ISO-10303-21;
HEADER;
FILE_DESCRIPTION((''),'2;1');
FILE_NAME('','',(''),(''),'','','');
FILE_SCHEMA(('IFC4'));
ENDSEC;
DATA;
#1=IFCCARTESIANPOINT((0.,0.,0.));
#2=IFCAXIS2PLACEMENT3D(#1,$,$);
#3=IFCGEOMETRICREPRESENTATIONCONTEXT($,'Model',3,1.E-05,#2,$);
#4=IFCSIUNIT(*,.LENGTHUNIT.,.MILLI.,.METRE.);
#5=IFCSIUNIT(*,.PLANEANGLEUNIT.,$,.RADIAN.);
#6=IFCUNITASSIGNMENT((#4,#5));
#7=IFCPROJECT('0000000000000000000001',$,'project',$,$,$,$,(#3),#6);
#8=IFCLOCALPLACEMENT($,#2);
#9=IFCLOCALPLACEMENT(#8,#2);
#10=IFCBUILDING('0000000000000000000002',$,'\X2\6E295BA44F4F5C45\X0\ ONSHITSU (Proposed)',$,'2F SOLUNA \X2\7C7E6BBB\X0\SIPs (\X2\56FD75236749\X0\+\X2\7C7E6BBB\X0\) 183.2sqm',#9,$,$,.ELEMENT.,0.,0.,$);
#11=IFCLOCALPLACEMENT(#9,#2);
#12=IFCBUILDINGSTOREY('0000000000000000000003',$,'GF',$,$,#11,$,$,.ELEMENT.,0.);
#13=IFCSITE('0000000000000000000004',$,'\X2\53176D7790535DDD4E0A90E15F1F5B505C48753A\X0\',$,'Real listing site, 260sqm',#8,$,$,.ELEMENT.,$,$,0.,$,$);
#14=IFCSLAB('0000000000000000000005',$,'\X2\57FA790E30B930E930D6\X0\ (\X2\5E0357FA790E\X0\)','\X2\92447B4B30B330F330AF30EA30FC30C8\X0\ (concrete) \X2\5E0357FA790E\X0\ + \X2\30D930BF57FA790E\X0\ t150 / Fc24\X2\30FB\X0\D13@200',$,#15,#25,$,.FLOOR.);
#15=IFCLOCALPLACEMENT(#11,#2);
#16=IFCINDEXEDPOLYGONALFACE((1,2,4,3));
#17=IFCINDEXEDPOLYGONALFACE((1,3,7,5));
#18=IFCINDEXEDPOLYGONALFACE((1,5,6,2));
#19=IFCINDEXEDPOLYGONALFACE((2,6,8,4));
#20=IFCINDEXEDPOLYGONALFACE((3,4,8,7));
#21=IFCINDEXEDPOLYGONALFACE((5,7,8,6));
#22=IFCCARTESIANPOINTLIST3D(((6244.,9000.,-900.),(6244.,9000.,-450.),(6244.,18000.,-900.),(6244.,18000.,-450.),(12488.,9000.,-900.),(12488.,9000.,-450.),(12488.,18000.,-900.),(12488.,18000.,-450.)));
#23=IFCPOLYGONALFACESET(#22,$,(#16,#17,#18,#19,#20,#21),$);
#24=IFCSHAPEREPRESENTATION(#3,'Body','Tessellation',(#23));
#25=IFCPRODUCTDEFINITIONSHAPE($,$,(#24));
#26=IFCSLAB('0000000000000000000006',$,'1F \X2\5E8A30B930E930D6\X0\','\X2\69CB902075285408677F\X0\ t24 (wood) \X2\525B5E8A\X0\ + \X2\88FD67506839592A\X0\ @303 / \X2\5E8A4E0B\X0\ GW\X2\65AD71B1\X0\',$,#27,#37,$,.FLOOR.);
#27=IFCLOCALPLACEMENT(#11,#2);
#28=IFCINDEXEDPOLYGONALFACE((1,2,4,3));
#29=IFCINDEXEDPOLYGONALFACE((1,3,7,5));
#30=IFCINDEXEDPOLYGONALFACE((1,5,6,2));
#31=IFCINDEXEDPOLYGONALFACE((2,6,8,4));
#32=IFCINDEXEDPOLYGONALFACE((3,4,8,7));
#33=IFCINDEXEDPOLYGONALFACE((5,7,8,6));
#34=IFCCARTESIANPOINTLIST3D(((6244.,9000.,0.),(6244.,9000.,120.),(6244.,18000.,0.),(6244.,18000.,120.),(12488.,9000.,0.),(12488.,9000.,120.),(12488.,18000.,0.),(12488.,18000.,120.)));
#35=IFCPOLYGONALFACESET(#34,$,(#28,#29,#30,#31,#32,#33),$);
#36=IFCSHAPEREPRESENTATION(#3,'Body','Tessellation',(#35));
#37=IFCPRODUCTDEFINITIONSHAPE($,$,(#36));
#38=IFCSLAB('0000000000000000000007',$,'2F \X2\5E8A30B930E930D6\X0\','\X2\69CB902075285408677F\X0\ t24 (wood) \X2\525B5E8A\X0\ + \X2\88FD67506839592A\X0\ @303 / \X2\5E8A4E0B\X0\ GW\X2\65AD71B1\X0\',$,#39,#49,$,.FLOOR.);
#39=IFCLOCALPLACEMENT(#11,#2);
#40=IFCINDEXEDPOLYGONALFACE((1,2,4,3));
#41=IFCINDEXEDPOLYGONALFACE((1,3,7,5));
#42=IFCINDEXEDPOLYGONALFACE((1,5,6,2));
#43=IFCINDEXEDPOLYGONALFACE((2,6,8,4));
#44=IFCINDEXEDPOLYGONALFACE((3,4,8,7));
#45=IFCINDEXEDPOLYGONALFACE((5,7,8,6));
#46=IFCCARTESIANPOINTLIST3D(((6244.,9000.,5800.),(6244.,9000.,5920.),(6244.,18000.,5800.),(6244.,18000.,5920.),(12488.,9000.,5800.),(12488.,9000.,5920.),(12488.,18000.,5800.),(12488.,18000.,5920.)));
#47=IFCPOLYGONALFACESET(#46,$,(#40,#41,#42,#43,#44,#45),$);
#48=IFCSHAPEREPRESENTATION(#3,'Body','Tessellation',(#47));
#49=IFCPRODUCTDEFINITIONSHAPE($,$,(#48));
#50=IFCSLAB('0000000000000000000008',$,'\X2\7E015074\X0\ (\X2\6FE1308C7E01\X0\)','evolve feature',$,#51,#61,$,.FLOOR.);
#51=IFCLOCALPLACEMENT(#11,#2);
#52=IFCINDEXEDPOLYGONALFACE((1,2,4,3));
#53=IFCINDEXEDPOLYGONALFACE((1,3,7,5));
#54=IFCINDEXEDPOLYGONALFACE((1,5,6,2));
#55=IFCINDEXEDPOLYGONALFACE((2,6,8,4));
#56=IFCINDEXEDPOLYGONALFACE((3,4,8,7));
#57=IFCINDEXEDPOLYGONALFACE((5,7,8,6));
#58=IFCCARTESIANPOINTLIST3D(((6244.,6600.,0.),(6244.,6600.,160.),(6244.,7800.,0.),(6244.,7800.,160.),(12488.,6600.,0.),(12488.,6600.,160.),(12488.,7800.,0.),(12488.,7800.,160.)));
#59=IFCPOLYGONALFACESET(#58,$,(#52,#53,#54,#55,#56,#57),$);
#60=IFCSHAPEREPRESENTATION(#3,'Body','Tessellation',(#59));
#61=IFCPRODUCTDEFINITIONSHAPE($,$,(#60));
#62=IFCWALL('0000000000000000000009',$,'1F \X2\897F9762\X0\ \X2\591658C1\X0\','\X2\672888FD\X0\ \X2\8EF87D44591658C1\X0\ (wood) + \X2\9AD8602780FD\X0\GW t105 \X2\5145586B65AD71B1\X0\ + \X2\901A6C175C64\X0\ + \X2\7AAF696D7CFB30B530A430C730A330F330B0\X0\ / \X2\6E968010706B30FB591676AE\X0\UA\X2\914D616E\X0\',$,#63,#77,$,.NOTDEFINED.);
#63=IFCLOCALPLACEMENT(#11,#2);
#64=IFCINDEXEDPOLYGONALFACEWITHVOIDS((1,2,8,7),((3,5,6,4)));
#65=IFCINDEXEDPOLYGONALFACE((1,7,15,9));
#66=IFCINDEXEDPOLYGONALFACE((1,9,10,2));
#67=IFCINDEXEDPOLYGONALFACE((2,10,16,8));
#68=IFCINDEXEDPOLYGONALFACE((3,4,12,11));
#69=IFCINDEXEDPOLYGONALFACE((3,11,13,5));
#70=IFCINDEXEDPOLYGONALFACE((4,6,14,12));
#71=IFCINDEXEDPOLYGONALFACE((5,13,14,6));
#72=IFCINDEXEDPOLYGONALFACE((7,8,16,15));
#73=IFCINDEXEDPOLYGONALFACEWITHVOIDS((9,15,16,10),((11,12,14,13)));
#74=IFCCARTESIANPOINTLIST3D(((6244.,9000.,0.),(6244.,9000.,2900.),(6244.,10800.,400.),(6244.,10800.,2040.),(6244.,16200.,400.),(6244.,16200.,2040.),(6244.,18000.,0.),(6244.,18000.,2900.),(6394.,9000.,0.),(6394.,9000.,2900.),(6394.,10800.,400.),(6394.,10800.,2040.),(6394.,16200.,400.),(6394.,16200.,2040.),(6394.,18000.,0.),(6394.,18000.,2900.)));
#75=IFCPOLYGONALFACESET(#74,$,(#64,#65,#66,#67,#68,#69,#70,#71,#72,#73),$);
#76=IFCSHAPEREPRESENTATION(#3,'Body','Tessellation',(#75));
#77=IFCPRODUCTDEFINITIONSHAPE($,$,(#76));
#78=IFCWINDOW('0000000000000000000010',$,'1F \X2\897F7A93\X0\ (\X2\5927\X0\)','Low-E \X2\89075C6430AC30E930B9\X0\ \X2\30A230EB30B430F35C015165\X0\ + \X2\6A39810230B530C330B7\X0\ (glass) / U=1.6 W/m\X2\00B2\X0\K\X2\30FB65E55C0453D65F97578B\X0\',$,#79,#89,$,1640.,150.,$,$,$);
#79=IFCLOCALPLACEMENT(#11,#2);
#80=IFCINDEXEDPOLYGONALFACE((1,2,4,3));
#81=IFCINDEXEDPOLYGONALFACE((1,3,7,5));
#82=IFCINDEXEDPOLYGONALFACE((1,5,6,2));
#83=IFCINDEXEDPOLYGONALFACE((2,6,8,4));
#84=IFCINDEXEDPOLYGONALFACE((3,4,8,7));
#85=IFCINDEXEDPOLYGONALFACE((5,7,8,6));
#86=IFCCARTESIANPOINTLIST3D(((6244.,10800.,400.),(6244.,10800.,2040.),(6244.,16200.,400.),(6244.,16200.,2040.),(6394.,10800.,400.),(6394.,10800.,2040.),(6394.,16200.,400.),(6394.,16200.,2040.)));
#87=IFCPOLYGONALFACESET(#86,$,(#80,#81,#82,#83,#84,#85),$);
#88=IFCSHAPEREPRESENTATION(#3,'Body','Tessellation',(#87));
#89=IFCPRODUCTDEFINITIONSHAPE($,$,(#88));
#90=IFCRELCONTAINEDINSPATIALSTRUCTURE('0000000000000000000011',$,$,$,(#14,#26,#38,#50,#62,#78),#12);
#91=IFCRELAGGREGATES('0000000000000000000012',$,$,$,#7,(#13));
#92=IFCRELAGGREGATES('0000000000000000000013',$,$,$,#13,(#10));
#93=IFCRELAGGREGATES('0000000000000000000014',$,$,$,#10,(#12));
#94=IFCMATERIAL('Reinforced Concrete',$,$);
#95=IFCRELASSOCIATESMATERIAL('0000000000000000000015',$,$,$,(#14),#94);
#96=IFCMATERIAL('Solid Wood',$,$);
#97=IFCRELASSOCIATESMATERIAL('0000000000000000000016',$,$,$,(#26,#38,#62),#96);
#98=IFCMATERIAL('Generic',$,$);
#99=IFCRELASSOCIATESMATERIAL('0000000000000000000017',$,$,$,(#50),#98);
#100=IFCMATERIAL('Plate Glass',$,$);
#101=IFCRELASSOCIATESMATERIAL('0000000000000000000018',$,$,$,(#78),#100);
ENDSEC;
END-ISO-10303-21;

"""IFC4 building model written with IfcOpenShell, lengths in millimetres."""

from ifc_helpers import new_model, si_unit, frame, frame_2d, origin, place, context, project, spatial, rectangle, extrude, material, element, fill, save


model = new_model("IFC4")

# Units and contexts
model_context = context("Model", 3, precision=1e-05, world=origin())
ifc_project = project(units=[si_unit("LENGTHUNIT", "METRE", prefix="MILLI"), si_unit("PLANEANGLEUNIT", "RADIAN")], contexts=[model_context])

# Site, building, storey
site_placement = place(None, origin())
site = spatial("IfcSite", under=ifc_project, at=site_placement, Name="北海道川上郡弟子屈町", ObjectType="Real listing site, 260sqm", CompositionType="ELEMENT", RefElevation=0.0)
building_placement = place(site_placement, origin())
building = spatial("IfcBuilding", under=site, at=building_placement, Name="温室住居 ONSHITSU (Proposed)", ObjectType="2F SOLUNA 籾殻SIPs (国産杉+籾殻) 183.2sqm", CompositionType="ELEMENT", ElevationOfRefHeight=0.0, ElevationOfTerrain=0.0)
storey_placement = place(building_placement, origin())
storey = spatial("IfcBuildingStorey", under=building, at=storey_placement, Name="GF", CompositionType="ELEMENT", Elevation=0.0)

# Slabs
ifc_material_1 = material(Name="Reinforced Concrete")
slab_1_placement = place(storey_placement, frame((3122.0, 4500.0, -450.0)))
element("IfcSlab", 1, at=slab_1_placement, inside=storey, material=ifc_material_1, Name="基礎スラブ (布基礎)", Description="鉄筋コンクリート (concrete) 布基礎 + ベタ基礎 t150 / Fc24・D13@200", PredefinedType="FLOOR", context=model_context, shape_type="SweptSolid", body=[
    extrude(rectangle(XDim=6244.0, YDim=9000.0, at=frame_2d((3122.0, 4500.0))), frame((3122.0, 4500.0, -450.0)), (0.0, 0.0, 1.0), 450.0),
])
ifc_material_2 = material(Name="Solid Wood")
slab_2_placement = place(storey_placement, frame((3122.0, 4500.0, 0.0)))
element("IfcSlab", 2, at=slab_2_placement, inside=storey, material=ifc_material_2, Name="1F 床スラブ", Description="構造用合板 t24 (wood) 剛床 + 製材根太 @303 / 床下 GW断熱", PredefinedType="FLOOR", context=model_context, shape_type="SweptSolid", body=[
    extrude(rectangle(XDim=6244.0, YDim=9000.0, at=frame_2d((3122.0, 4500.0))), frame((3122.0, 4500.0, 0.0)), (0.0, 0.0, 1.0), 120.0),
])
slab_3_placement = place(storey_placement, frame((3122.0, 4500.0, 2900.0)))
element("IfcSlab", 3, at=slab_3_placement, inside=storey, material=ifc_material_2, Name="2F 床スラブ", Description="構造用合板 t24 (wood) 剛床 + 製材根太 @303 / 床下 GW断熱", PredefinedType="FLOOR", context=model_context, shape_type="SweptSolid", body=[
    extrude(rectangle(XDim=6244.0, YDim=9000.0, at=frame_2d((3122.0, 4500.0))), frame((3122.0, 4500.0, 2900.0)), (0.0, 0.0, 1.0), 120.0),
])
ifc_material_3 = material(Name="Generic")
slab_4_placement = place(storey_placement, frame((3122.0, 3300.0, 0.0)))
element("IfcSlab", 4, at=slab_4_placement, inside=storey, material=ifc_material_3, Name="縁側 (濡れ縁)", Description="evolve feature", PredefinedType="FLOOR", context=model_context, shape_type="SweptSolid", body=[
    extrude(rectangle(XDim=6244.0, YDim=1200.0, at=frame_2d((3122.0, 600.0))), frame((3122.0, 3300.0, 0.0)), (0.0, 0.0, 1.0), 160.0),
])

# Shared definitions
ifc_material_4 = material(Name="Plate Glass")

# Wall, opening, window
wall_1_placement = place(storey_placement, frame((3122.0, 4500.0, 0.0)))
wall_1 = element("IfcWall", 5, at=wall_1_placement, inside=storey, material=ifc_material_2, Name="1F 西面 外壁", Description="木製 軸組外壁 (wood) + 高性能GW t105 充填断熱 + 通気層 + 窯業系サイディング / 準耐火・外皮UA配慮", PredefinedType="NOTDEFINED", context=model_context, shape_type="SweptSolid", body=[
    extrude(rectangle(XDim=150.0, YDim=9000.0, at=frame_2d((75.0, 4500.0))), frame((3122.0, 4500.0, 0.0)), (0.0, 0.0, 1.0), 2900.0),
])
opening_1_placement = place(storey_placement, frame((3122.0, 5400.0, 200.0)))
opening_1 = element("IfcOpeningElement", 6, at=opening_1_placement, cuts=wall_1, PredefinedType="NOTDEFINED", context=model_context, shape_type="SweptSolid", body=[
    extrude(rectangle(XDim=150.0, YDim=5400.0, at=frame_2d((75.0, 2700.0))), frame((3122.0, 5400.0, 200.0)), (0.0, 0.0, 1.0), 1640.0),
])
window_1_placement = place(storey_placement, frame((3122.0, 5400.0, 200.0)))
window_1 = element("IfcWindow", 7, at=window_1_placement, inside=storey, material=ifc_material_4, Name="1F 西窓 (大)", Description="Low-E 複層ガラス アルゴン封入 + 樹脂サッシ (glass) / U=1.6 W/m²K・日射取得型", OverallHeight=1640.0, OverallWidth=150.0, context=model_context, shape_type="SweptSolid", body=[
    extrude(rectangle(XDim=150.0, YDim=5400.0, at=frame_2d((75.0, 2700.0))), frame((3122.0, 5400.0, 200.0)), (0.0, 0.0, 1.0), 1640.0),
])
fill(opening_1, window_1)

save(model, "model.ifc")
